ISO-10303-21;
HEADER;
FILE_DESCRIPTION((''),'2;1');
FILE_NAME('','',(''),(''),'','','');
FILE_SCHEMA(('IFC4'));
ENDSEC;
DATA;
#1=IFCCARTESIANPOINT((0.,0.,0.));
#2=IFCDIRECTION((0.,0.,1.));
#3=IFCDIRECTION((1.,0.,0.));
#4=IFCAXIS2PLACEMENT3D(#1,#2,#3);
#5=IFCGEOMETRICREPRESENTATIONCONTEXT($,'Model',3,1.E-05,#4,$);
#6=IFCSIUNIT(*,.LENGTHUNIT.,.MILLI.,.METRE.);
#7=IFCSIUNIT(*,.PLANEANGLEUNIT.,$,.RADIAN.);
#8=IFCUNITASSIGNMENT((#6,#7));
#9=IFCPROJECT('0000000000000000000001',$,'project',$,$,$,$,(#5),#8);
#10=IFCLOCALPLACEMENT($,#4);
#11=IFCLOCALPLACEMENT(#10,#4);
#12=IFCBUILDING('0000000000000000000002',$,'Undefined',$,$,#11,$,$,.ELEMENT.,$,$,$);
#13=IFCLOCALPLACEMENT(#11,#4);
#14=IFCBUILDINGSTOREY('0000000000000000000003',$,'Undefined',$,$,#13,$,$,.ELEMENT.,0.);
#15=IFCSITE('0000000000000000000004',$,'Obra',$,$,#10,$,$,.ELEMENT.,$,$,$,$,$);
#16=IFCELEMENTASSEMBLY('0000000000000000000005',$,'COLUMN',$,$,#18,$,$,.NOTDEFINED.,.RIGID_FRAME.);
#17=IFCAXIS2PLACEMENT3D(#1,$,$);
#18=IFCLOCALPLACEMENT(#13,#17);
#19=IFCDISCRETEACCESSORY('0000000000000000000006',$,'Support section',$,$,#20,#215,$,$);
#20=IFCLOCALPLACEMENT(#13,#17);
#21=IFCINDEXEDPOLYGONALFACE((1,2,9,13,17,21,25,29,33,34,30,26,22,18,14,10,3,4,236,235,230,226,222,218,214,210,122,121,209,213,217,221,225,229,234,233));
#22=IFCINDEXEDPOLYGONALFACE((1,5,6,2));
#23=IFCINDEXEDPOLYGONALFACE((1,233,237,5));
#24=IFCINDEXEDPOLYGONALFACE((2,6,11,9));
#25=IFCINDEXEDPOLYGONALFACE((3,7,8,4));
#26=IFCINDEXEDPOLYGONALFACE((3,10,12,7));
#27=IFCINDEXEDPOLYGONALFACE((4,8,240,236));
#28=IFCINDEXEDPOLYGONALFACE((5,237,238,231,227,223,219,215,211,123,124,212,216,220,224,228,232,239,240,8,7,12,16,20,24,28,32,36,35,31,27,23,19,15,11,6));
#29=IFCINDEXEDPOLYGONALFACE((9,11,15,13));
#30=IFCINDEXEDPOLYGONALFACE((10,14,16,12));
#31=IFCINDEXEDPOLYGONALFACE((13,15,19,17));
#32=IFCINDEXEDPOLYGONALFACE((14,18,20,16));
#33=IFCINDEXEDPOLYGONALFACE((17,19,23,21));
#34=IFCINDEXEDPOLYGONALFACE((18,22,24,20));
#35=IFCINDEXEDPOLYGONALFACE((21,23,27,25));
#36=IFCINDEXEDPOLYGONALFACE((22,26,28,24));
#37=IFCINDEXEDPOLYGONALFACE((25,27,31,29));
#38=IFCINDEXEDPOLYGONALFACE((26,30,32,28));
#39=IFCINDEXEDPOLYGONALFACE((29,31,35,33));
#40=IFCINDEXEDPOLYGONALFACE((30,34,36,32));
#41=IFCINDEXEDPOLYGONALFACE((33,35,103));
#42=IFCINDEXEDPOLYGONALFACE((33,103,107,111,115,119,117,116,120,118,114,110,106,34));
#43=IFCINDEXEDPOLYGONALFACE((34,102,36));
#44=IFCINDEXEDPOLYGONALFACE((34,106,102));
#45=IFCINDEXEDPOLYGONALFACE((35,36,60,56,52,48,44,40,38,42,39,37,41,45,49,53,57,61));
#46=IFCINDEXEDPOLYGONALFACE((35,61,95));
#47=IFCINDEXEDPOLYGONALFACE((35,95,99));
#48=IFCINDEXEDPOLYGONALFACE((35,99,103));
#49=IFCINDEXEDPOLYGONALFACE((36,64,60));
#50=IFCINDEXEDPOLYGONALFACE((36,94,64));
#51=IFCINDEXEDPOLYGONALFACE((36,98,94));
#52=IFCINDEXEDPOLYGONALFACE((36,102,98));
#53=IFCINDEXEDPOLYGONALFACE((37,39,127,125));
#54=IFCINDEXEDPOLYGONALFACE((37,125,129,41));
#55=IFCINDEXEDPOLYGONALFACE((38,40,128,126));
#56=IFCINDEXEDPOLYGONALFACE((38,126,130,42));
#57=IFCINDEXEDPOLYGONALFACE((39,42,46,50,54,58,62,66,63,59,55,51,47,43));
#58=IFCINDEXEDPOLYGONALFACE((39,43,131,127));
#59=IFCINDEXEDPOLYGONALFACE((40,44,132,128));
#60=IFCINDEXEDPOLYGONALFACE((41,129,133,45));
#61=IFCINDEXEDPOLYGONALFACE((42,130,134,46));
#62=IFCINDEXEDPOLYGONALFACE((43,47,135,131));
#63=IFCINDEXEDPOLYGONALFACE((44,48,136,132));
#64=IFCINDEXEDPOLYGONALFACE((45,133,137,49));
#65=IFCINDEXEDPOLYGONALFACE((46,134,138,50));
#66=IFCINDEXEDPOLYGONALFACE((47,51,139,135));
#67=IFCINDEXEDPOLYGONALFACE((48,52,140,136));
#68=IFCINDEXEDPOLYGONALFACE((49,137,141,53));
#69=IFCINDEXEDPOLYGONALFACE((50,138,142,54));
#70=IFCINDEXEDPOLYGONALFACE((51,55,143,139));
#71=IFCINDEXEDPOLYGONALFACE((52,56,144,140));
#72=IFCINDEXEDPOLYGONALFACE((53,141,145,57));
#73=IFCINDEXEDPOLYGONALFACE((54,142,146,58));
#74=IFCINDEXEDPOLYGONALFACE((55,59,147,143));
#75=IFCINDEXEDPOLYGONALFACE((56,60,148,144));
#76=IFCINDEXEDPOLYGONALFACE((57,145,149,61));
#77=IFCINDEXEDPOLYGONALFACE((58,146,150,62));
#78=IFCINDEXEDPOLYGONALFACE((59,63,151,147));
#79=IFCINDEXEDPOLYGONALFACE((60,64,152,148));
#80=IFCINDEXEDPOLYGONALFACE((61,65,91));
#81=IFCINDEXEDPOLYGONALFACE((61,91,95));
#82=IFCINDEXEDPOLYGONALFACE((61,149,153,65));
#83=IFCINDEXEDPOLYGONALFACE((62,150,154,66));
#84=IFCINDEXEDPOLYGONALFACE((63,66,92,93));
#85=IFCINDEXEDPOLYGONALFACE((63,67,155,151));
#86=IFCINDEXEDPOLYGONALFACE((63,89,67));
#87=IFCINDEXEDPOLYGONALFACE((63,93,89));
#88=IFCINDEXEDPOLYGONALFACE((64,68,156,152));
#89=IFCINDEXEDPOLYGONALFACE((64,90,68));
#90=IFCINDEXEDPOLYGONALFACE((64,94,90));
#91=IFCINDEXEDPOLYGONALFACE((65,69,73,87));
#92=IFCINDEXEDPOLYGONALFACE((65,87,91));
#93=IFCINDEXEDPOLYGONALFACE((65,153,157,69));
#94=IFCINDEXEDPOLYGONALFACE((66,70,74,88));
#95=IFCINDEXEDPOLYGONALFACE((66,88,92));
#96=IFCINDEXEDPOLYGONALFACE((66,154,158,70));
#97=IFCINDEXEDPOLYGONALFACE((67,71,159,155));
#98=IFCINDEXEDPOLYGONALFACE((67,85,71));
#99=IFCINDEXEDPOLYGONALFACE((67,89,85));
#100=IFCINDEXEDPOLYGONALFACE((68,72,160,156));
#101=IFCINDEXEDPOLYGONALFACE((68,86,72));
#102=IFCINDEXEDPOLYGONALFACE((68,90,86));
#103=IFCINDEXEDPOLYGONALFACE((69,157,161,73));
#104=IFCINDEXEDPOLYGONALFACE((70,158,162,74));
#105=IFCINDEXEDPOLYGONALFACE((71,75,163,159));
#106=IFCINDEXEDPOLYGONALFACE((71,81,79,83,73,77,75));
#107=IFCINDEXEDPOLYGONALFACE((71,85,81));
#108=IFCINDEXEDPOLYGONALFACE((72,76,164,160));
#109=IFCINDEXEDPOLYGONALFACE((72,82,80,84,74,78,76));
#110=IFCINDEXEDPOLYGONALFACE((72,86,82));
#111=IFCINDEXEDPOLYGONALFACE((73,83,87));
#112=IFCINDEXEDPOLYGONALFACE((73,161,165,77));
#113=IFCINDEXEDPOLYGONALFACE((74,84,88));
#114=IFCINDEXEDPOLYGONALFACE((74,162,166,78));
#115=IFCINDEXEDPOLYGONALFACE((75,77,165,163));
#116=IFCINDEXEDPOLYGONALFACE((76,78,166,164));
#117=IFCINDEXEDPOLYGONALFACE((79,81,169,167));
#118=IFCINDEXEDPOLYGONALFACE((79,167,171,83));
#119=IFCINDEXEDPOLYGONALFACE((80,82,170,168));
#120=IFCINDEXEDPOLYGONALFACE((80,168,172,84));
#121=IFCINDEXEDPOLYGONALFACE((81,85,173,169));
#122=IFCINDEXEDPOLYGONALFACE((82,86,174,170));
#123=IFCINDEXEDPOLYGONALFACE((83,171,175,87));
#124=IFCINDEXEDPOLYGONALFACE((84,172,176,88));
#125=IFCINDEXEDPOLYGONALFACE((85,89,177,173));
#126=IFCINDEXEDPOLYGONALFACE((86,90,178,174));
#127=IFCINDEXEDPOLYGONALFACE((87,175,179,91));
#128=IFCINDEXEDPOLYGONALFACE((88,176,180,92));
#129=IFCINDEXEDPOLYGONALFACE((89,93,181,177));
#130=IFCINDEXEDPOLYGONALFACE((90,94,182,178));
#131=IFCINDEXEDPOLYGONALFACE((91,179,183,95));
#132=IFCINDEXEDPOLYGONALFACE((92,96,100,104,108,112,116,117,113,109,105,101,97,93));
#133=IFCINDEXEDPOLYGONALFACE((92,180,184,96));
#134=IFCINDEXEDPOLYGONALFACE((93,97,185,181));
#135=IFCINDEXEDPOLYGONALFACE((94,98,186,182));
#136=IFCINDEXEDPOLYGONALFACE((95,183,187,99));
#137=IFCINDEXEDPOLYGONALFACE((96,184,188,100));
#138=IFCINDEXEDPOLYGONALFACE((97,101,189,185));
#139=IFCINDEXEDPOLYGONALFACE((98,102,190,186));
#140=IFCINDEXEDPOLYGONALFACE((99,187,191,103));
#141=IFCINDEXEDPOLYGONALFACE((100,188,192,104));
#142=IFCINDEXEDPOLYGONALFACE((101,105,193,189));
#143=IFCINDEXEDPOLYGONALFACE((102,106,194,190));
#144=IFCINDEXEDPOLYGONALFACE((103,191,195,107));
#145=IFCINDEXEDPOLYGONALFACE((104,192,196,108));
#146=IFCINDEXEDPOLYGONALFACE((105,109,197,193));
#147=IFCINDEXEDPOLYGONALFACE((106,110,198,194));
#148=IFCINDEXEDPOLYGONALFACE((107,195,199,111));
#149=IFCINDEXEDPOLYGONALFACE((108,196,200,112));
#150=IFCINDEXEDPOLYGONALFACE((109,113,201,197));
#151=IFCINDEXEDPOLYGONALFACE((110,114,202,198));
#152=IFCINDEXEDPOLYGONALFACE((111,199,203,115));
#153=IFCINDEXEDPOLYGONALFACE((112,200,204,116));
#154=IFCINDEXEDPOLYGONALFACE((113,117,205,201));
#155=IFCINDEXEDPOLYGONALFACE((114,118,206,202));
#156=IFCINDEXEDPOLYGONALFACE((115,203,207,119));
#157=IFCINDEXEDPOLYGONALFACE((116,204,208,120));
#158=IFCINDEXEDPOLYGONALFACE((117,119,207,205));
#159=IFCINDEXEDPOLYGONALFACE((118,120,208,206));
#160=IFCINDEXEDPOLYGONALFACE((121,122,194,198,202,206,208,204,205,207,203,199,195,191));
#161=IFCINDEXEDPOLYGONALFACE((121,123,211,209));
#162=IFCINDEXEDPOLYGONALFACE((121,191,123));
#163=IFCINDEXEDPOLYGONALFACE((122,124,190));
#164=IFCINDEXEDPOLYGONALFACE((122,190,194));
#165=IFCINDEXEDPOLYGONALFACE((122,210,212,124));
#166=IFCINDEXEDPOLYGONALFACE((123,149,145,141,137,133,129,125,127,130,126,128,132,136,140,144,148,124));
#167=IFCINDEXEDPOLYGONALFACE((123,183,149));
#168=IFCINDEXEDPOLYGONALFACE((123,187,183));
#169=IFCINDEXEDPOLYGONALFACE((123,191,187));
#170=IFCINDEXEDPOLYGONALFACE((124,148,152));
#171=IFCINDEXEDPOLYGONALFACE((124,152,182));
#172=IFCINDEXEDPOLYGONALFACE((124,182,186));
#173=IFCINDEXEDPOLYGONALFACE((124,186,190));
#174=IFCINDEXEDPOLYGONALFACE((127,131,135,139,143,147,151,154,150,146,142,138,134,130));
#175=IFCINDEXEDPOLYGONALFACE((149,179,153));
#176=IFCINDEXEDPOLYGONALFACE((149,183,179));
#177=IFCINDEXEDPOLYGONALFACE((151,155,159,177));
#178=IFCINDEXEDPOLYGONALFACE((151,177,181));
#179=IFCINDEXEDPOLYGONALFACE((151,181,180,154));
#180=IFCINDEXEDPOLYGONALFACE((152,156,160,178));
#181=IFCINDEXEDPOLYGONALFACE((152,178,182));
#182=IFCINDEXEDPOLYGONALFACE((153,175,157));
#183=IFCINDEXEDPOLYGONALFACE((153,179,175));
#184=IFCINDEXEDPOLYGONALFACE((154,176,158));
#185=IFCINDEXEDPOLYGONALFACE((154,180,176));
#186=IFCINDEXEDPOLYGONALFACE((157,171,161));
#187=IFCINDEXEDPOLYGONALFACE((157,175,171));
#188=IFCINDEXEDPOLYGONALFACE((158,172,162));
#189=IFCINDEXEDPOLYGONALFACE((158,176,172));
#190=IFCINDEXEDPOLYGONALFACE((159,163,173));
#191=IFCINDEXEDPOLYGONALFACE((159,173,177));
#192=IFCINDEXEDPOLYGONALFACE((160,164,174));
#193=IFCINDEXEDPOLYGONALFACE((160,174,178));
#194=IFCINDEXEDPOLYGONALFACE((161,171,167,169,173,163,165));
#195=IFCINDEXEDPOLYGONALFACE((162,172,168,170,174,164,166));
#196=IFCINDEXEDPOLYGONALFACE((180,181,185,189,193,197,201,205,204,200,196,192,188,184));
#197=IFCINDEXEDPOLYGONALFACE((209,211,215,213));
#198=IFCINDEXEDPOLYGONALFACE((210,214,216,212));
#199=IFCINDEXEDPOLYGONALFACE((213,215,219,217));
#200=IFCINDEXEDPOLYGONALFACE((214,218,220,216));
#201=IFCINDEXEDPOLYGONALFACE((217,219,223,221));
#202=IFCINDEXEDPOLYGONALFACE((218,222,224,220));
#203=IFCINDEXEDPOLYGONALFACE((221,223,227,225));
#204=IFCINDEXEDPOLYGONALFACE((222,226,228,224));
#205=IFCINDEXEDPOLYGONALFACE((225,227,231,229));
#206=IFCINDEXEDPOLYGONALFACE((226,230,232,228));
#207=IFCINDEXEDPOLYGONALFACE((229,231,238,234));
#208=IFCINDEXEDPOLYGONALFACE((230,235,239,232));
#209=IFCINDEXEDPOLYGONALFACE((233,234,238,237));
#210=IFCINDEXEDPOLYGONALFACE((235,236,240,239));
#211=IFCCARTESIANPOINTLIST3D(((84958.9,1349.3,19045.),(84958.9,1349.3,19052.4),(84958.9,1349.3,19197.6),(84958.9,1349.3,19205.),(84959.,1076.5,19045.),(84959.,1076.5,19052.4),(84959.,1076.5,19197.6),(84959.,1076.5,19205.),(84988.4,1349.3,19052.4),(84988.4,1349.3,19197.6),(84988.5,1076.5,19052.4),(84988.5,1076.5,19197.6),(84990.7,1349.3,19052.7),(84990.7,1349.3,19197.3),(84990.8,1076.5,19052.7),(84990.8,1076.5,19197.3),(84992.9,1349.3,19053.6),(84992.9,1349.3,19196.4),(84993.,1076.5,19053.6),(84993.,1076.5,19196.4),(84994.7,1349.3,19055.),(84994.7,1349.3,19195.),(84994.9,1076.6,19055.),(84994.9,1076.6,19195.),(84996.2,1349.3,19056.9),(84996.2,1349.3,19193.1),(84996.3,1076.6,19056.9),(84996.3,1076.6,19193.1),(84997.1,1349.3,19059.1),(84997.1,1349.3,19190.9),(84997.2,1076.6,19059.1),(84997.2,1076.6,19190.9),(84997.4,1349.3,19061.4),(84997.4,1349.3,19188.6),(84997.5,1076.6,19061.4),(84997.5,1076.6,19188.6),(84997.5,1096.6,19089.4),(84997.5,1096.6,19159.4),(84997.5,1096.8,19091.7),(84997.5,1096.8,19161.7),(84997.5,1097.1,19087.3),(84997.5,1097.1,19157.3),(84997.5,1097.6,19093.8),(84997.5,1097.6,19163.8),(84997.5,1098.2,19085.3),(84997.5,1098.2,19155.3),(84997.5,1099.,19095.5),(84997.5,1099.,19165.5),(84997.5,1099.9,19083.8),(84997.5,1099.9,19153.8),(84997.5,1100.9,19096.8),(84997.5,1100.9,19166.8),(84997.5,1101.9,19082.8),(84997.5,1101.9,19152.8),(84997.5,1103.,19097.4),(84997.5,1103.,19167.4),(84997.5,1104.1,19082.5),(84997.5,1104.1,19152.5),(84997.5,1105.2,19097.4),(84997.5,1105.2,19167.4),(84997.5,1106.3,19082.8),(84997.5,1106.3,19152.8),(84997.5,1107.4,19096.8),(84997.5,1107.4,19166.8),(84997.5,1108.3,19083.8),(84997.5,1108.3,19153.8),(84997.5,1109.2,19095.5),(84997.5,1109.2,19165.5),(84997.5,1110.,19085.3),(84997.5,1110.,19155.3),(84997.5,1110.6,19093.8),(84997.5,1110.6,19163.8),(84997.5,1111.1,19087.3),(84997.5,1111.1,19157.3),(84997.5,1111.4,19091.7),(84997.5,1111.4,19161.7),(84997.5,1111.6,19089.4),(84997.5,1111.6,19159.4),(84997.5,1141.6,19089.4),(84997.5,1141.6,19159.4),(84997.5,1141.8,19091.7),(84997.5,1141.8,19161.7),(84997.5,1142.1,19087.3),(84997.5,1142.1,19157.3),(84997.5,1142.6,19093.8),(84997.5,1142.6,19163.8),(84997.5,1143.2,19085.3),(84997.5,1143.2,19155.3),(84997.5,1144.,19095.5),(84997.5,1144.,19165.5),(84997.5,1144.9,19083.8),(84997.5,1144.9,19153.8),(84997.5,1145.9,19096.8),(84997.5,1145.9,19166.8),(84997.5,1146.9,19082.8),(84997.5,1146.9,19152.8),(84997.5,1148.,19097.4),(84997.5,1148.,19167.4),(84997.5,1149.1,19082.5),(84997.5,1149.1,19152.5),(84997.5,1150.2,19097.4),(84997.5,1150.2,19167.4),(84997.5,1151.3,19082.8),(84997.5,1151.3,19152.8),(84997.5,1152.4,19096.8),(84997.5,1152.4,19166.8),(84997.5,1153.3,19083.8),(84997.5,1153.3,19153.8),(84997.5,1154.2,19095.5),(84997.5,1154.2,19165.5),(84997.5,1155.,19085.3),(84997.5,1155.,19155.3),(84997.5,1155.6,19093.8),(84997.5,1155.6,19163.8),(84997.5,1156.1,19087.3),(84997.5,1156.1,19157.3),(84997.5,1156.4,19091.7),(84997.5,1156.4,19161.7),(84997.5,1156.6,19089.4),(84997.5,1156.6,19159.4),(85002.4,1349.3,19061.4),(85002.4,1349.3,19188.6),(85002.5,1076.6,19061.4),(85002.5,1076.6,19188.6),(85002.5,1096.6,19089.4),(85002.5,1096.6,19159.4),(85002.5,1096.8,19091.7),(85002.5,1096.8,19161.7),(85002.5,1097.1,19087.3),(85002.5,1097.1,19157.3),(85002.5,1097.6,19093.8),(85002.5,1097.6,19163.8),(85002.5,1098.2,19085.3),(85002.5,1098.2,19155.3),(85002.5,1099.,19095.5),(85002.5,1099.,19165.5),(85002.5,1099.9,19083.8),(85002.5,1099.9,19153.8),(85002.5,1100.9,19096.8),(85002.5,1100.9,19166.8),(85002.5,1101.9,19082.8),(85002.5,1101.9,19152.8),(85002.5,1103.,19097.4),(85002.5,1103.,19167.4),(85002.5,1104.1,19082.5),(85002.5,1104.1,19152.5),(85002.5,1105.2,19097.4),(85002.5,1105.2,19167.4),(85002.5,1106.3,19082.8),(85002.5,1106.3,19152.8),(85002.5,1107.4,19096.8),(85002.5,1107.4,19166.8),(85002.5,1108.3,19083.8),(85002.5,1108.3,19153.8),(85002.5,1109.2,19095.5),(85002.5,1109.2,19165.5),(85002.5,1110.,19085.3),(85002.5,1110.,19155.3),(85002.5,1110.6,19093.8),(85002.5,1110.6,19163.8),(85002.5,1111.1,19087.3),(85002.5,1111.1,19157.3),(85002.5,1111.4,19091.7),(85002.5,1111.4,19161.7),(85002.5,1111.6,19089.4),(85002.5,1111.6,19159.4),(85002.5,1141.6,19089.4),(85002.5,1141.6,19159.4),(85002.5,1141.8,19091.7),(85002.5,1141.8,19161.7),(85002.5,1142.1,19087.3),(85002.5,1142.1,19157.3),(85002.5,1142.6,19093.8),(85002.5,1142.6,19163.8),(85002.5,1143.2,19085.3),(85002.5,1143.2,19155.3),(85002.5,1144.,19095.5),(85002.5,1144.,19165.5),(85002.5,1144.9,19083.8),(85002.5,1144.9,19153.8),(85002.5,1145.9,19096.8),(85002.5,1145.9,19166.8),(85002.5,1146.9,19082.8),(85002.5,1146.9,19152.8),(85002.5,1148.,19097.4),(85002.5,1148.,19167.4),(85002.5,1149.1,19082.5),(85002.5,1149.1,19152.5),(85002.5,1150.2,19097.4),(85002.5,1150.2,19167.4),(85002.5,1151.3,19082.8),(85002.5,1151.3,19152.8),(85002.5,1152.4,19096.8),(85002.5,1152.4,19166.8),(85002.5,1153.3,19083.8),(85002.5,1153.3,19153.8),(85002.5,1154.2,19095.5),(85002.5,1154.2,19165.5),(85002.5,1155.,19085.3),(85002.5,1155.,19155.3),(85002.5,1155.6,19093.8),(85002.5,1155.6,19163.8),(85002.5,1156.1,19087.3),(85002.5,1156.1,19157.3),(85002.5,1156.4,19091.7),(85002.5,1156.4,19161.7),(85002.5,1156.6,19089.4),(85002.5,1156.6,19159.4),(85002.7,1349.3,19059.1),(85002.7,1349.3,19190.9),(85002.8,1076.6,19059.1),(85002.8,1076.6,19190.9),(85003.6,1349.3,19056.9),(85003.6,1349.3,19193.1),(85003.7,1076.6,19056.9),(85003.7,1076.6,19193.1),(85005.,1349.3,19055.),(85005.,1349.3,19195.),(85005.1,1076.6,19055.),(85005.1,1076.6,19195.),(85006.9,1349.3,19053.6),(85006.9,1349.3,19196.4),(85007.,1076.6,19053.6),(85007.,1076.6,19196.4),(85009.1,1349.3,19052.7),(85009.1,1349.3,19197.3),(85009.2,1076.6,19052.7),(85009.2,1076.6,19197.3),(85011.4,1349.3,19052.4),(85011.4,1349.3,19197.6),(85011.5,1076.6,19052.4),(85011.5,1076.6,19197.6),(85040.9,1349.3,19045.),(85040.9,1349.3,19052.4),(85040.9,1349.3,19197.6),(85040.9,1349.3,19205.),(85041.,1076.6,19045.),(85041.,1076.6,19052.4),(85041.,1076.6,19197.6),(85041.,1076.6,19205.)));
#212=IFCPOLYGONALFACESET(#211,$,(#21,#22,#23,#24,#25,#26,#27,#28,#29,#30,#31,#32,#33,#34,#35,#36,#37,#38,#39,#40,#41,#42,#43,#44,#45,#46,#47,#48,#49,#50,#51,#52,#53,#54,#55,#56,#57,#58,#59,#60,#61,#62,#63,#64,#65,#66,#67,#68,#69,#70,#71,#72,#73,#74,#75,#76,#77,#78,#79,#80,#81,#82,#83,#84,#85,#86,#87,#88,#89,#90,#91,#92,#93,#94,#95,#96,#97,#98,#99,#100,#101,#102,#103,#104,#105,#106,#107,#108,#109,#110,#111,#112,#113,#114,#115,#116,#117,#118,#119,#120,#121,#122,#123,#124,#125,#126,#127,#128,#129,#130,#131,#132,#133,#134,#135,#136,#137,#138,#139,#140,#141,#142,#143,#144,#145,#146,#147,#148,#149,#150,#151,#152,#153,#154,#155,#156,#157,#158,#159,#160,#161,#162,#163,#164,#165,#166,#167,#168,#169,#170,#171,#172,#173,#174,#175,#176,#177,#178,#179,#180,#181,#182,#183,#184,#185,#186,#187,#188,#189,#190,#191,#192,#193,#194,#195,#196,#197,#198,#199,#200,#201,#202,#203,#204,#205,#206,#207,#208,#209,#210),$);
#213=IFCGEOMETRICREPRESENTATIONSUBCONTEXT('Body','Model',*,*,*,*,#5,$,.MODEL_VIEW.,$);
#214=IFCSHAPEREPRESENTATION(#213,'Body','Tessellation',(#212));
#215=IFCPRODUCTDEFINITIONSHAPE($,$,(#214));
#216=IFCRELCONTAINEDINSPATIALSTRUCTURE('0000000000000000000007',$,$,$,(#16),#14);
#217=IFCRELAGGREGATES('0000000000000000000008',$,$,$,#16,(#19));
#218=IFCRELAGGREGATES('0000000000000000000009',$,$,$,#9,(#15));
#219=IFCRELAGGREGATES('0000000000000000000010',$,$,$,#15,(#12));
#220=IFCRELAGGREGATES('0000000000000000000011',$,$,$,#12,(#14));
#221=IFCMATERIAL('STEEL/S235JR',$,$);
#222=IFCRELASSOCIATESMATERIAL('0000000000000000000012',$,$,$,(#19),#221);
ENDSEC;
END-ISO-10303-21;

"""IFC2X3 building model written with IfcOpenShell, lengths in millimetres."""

from ifc_helpers import new_model, si_unit, frame, origin_with_axes, origin_2d_with_axis, place, context, subcontext, project, spatial, circle, i_section, extrude, clip, halfspace, source, transform, mapped, material, element, aggregate, save


model = new_model("IFC2X3")

# Units and contexts
model_context = context("Model", 3, precision=1e-05, world=origin_with_axes())
body_context = subcontext(model_context, "Body", "Model", "MODEL_VIEW")
ifc_project = project(units=[si_unit("LENGTHUNIT", "METRE", prefix="MILLI"), si_unit("PLANEANGLEUNIT", "RADIAN")], contexts=[model_context])

# Site, building, storey
site_placement = place(None, origin_with_axes())
site = spatial("IfcSite", under=ifc_project, at=site_placement, Name="Obra", CompositionType="ELEMENT")
building_placement = place(site_placement, origin_with_axes())
building = spatial("IfcBuilding", under=site, at=building_placement, Name="Undefined", CompositionType="ELEMENT")
storey_placement = place(building_placement, origin_with_axes())
storey = spatial("IfcBuildingStorey", under=building, at=storey_placement, Name="Undefined", CompositionType="ELEMENT", Elevation=0.0)

# Shared definitions
ifc_material_1 = material(Name="STEEL/S235JR")
shared_shape_1 = source(origin_with_axes(), body_context, "Body", "SweptSolid", [
    extrude(circle(Radius=7.5, at=origin_2d_with_axis()), frame((0.0, -2.6, 0.0), z_axis=(0.0, 1.0, 0.0), x_axis=(1.0, 0.0, 0.0)), (0.0, 0.0, 1.0), 5.2),
])

# Element assembly, discrete accessory, opening
assembly_1_placement = place(storey_placement, origin_with_axes())
assembly_1 = element("IfcElementAssembly", 1, at=assembly_1_placement, inside=storey, Name="COLUMN", AssemblyPlace="NOTDEFINED", PredefinedType="RIGID_FRAME")
discrete_accessory_1_placement = place(assembly_1_placement, frame((84999.9, 1349.3, 19125.0), z_axis=(0.0, 0.0, 1.0), x_axis=(0.000434, -1.0, 0.0)))
discrete_accessory_1 = element("IfcDiscreteAccessory", 2, at=discrete_accessory_1_placement, material=ifc_material_1, Name="Support section", context=body_context, shape_type="Clipping", body=[
    clip(extrude(i_section(OverallWidth=82.0, OverallDepth=160.0, WebThickness=5.0, FlangeThickness=7.4, FilletRadius=9.0, at=origin_2d_with_axis()), frame((272.7, 0.0, 0.0), z_axis=(-1.0, 0.0, 0.0), x_axis=(0.0, -1.0, 0.0)), (0.0, 0.0, 1.0), 272.8), halfspace(frame((272.7, 0.0, -180.0), z_axis=(-1.0, 0.000434, 0.0), x_axis=(0.000434, 1.0, 0.0)), True)),
])
opening_1_placement = place(assembly_1_placement, frame((85000.0, 1126.6, 19160.0), z_axis=(0.0, 1.0, 0.0), x_axis=(0.0, 0.0, -1.0)))
element("IfcOpeningElement", 3, at=opening_1_placement, cuts=discrete_accessory_1, ObjectType="Opening", context=body_context, shape_type="MappedRepresentation", body=[
    mapped(shared_shape_1, transform((0.0, 0.0, -22.5))),
    mapped(shared_shape_1, transform((70.0, 0.0, -22.5))),
    mapped(shared_shape_1, transform((0.0, 0.0, 22.5))),
    mapped(shared_shape_1, transform((70.0, 0.0, 22.5))),
])
aggregate(assembly_1, [discrete_accessory_1])

save(model, "model.ifc")
